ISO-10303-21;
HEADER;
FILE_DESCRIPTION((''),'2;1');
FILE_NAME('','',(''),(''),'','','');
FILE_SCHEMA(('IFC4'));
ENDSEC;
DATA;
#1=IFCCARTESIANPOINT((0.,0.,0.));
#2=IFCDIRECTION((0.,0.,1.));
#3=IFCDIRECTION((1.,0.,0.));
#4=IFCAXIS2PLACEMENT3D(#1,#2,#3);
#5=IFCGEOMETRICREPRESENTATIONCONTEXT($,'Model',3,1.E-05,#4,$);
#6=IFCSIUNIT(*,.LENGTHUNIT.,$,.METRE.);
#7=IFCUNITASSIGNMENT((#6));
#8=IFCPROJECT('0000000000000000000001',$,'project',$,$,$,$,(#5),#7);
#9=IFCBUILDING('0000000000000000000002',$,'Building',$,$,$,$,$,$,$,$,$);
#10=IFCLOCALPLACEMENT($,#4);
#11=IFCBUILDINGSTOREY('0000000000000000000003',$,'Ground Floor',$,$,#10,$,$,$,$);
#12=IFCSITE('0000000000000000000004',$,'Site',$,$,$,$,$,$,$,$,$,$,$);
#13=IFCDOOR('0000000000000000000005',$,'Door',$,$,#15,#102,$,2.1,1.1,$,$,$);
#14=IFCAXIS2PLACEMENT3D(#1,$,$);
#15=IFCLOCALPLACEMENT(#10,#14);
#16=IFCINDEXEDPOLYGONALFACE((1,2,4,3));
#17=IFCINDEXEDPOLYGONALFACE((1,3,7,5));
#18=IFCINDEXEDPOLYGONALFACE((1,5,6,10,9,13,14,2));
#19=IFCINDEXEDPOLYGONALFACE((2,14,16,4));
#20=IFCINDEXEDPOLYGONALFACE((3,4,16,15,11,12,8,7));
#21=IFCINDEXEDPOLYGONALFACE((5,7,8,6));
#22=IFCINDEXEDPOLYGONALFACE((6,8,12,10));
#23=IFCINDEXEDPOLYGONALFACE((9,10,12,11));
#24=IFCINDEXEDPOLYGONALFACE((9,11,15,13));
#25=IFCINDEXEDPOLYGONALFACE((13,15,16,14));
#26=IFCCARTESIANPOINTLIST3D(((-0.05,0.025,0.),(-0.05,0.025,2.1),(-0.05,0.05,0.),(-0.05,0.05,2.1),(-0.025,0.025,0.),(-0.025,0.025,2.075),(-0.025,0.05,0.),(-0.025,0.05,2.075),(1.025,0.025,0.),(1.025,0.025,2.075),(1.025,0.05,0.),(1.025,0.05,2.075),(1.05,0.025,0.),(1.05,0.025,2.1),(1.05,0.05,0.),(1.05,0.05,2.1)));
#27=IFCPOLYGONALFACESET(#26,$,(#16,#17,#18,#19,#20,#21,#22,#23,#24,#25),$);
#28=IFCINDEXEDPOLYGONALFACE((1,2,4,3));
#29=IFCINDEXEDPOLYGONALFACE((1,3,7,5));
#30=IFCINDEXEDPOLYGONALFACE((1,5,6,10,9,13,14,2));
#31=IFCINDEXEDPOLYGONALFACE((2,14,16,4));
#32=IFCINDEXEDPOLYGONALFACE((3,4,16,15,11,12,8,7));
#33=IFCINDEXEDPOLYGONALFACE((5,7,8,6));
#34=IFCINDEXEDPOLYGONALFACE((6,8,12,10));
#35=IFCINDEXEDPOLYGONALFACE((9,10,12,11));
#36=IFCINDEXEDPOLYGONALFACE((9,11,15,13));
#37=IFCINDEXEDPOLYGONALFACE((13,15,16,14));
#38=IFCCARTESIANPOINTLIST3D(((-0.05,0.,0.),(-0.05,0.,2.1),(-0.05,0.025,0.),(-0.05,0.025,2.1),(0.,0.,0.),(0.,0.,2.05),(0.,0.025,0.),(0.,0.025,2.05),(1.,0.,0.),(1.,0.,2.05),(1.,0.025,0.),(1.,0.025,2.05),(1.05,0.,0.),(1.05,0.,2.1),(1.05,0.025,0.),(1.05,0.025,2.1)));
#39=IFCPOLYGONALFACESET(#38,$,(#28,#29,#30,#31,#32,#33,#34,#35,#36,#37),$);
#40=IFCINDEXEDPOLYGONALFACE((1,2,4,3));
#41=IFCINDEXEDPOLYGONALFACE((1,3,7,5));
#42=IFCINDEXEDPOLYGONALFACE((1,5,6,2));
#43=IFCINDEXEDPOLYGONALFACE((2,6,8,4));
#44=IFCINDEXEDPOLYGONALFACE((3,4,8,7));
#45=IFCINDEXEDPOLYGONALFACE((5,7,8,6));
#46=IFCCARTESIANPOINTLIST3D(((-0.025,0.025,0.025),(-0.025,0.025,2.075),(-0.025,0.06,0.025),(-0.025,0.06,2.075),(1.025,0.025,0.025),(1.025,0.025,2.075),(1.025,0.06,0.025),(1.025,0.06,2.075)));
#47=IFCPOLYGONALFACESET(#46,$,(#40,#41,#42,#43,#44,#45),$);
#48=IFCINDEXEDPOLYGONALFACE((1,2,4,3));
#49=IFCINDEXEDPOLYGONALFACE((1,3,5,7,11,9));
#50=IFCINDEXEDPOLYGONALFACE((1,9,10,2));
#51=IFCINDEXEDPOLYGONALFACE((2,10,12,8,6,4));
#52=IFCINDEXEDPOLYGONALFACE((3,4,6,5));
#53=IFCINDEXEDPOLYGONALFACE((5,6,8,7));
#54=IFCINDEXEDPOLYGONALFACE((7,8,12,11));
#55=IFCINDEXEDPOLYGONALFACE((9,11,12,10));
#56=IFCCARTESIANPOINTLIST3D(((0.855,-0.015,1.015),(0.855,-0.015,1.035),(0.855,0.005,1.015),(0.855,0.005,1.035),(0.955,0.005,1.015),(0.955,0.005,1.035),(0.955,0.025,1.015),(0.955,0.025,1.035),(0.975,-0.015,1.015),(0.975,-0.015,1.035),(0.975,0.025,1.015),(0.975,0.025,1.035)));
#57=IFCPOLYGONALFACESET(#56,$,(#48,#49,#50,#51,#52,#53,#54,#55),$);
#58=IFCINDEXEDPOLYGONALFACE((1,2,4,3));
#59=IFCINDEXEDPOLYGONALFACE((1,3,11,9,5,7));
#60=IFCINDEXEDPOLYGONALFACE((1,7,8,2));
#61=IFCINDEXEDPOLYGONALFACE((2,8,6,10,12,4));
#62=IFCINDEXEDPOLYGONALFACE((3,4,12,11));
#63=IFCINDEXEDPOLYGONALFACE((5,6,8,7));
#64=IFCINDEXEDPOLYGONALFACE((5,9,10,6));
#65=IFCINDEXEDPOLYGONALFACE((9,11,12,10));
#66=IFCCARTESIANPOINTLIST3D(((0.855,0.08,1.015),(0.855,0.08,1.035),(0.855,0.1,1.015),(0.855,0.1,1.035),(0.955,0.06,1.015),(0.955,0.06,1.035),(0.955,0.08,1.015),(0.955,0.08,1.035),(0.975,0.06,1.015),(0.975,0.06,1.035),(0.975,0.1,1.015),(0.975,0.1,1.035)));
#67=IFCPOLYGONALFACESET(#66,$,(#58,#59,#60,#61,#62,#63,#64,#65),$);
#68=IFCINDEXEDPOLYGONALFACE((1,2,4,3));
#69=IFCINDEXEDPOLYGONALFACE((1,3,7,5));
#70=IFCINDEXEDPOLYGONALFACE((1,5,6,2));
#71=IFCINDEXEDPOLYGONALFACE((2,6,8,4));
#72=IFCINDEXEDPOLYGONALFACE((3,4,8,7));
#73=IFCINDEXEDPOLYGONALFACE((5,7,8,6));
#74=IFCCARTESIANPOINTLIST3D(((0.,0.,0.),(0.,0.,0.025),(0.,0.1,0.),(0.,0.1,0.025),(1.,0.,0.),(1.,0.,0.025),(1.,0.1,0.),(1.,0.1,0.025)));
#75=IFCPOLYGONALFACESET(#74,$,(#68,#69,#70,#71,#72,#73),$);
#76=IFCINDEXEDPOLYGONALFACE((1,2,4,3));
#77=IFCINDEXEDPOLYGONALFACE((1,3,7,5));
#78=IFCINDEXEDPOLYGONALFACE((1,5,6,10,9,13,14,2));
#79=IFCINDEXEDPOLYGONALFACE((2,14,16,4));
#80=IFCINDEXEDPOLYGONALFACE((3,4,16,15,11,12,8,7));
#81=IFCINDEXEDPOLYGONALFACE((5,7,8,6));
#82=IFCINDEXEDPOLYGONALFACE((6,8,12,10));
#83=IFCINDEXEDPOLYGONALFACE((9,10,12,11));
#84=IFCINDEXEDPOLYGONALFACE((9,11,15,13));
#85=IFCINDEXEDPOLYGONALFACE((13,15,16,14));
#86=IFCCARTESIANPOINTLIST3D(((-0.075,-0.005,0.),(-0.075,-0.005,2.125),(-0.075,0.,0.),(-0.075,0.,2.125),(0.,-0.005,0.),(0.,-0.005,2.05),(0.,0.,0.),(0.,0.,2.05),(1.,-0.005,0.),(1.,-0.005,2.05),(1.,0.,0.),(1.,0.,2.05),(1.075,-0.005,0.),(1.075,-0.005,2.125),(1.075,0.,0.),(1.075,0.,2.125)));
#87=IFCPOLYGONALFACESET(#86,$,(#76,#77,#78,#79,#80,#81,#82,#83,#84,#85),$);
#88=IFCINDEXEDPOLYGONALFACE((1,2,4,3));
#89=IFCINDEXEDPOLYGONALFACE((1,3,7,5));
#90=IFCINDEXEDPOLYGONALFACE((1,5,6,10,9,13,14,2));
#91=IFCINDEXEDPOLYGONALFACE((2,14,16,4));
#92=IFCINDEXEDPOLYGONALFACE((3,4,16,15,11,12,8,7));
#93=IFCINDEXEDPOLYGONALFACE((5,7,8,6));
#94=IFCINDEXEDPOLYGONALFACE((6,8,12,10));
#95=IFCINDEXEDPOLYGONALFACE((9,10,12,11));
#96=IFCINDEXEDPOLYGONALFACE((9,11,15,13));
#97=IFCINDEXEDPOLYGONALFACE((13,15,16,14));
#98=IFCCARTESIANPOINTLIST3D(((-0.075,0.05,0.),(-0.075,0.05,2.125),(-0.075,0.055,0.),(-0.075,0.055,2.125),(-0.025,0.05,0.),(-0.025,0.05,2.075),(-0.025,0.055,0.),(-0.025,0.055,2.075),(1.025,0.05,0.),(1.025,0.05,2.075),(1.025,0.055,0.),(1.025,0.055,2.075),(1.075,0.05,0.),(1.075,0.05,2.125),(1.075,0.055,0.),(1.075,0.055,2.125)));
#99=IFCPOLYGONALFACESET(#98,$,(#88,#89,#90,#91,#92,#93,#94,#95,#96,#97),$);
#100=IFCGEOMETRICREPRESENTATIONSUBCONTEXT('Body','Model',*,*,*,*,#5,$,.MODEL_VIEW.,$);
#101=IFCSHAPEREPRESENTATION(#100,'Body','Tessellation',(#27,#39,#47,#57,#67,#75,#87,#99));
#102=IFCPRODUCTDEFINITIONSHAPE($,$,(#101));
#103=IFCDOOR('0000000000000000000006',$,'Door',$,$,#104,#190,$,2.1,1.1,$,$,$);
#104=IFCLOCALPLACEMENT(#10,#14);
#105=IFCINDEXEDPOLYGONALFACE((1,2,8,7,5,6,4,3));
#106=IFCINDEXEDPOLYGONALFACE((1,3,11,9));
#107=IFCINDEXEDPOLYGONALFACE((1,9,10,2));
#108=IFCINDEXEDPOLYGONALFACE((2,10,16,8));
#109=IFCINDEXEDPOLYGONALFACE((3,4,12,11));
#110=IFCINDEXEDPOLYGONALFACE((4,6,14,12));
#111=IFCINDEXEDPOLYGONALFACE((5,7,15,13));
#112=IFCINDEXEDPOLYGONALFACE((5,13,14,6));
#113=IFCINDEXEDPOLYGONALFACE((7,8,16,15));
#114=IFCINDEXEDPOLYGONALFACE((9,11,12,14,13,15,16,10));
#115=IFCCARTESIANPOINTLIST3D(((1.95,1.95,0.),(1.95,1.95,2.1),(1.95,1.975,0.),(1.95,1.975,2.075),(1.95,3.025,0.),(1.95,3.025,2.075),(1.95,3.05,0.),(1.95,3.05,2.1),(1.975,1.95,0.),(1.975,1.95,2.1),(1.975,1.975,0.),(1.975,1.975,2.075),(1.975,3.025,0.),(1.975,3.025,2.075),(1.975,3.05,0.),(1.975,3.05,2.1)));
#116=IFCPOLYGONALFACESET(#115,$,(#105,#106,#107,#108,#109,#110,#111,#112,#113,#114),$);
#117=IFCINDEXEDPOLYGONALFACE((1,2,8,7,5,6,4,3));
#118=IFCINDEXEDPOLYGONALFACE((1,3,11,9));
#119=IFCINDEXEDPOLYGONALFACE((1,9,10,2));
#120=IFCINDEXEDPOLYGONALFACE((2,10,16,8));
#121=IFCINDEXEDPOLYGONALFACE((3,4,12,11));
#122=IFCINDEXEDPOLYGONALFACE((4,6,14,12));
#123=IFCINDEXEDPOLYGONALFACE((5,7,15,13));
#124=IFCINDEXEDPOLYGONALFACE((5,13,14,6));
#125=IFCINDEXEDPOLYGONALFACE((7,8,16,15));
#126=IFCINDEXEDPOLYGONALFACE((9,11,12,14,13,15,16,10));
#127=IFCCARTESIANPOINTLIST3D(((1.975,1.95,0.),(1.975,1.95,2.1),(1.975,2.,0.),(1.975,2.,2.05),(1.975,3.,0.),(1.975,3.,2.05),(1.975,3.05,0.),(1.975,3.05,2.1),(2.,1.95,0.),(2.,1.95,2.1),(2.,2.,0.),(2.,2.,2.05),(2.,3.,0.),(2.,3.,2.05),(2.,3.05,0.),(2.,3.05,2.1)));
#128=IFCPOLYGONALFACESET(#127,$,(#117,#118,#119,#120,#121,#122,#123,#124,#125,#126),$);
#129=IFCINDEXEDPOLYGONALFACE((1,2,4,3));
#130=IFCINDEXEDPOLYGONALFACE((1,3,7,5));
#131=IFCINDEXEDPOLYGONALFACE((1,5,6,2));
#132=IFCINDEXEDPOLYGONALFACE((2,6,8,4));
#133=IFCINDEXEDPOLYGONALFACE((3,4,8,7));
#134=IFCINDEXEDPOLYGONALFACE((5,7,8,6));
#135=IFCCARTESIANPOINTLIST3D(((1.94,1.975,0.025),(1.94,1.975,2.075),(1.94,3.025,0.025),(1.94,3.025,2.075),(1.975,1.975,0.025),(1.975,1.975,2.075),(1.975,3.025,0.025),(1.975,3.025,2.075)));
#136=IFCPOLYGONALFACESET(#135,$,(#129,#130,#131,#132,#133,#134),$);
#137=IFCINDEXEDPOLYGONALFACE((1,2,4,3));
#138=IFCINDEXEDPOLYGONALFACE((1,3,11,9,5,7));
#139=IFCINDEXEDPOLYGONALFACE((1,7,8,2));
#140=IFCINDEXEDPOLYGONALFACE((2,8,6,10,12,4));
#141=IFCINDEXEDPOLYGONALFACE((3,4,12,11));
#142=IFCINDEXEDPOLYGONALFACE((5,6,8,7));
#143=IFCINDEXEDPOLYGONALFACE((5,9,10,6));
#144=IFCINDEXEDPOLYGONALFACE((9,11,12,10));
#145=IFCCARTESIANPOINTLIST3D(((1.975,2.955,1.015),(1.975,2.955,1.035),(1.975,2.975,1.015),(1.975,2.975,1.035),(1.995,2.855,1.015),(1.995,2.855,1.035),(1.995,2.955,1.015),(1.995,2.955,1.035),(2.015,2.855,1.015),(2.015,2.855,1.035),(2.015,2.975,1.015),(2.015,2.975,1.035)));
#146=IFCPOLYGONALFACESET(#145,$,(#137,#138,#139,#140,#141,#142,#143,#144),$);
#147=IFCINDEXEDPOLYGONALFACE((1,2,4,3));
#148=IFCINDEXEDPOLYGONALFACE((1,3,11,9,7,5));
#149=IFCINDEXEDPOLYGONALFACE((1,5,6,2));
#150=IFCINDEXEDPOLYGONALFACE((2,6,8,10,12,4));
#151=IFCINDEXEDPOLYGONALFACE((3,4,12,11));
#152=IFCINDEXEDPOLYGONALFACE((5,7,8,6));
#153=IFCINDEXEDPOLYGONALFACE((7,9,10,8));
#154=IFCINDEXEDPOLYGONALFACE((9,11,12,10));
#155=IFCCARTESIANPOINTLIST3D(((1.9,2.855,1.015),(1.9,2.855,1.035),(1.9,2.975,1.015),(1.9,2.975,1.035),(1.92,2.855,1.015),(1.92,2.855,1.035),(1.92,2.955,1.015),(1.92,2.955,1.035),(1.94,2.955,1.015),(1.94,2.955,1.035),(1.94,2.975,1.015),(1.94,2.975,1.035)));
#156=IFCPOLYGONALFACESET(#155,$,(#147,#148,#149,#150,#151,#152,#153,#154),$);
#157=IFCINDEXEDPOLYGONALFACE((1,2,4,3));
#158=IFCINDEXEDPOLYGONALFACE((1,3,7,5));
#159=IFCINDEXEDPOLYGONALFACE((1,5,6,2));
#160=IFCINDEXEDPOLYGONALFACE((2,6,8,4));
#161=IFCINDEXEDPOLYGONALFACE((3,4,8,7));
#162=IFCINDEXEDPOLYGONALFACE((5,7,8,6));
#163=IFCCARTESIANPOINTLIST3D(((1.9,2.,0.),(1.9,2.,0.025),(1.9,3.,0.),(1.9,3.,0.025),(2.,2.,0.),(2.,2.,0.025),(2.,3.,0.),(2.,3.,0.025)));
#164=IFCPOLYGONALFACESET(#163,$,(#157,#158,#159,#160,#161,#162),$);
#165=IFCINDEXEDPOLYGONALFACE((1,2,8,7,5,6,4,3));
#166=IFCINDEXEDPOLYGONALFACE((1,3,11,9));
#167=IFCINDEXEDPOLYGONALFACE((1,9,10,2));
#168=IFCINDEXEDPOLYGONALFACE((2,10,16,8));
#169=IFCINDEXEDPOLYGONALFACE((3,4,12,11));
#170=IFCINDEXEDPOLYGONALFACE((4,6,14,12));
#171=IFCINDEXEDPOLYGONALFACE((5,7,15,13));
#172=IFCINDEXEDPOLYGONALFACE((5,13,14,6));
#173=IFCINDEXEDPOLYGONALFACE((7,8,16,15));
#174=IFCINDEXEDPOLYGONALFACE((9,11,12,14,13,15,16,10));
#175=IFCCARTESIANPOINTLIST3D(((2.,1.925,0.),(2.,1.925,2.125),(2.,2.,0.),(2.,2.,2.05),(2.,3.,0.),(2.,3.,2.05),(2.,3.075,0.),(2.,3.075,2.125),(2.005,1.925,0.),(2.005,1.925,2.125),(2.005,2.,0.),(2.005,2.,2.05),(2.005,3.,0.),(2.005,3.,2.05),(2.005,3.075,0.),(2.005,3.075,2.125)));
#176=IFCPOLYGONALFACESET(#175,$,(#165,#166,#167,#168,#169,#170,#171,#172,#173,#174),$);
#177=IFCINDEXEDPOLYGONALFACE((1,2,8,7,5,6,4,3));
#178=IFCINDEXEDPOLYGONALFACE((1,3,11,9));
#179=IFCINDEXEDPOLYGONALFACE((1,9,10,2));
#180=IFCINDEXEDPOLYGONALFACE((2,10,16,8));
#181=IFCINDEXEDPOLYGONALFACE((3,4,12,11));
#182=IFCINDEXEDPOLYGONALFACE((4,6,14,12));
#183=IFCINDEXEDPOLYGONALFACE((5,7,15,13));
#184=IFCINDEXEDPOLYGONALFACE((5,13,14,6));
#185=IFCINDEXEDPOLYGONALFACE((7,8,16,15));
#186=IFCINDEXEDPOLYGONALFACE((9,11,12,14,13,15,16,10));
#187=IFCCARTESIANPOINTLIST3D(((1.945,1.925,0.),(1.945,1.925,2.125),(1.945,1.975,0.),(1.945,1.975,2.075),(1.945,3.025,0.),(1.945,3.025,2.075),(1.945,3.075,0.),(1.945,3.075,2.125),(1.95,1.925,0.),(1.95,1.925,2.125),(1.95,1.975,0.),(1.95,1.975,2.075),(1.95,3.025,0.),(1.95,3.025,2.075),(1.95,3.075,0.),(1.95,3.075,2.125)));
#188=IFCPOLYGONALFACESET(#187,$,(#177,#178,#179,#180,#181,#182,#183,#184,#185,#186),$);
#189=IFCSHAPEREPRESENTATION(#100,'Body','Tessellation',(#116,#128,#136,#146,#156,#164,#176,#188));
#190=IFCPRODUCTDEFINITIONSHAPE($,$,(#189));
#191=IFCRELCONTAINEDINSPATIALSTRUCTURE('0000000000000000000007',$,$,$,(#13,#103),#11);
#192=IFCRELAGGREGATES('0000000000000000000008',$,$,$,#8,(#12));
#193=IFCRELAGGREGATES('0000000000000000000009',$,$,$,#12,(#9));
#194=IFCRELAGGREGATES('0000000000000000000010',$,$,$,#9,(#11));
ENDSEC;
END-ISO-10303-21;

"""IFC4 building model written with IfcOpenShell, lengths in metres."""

from ifc_helpers import new_model, si_unit, frame, origin_with_axes, place, context, subcontext, project, spatial, line, indexed_curve, outline, extrude, element, save


model = new_model("IFC4")

# Units and contexts
model_context = context("Model", 3, precision=1e-05, world=origin_with_axes())
body_context = subcontext(model_context, "Body", "Model", "MODEL_VIEW")
ifc_project = project(units=[si_unit("LENGTHUNIT", "METRE")], contexts=[model_context])

# Site, building, storey
site = spatial("IfcSite", under=ifc_project, Name="Site")
building = spatial("IfcBuilding", under=site, Name="Building")
storey_placement = place(None, origin_with_axes())
storey = spatial("IfcBuildingStorey", under=building, at=storey_placement, Name="Ground Floor")

# Doors
door_1_placement = place(storey_placement, frame((-0.05, 0.0, 0.0), z_axis=(0.0, 0.0, 1.0), x_axis=(1.0, 0.0, 0.0)))
element("IfcDoor", 1, at=door_1_placement, inside=storey, Name="Door", OverallHeight=2.1, OverallWidth=1.1, context=body_context, shape_type="SweptSolid", body=[
    extrude(outline(indexed_curve([(0.0, 0.0), (0.0, 2.1), (1.1, 2.1), (1.1, 0.0), (1.075, 0.0), (1.075, 2.075), (0.025, 2.075), (0.025, 0.0)], segments=[line(1, 2, 3, 4, 5, 6, 7, 8, 1)])), frame((0.0, 0.025, 0.0), z_axis=(0.0, -1.0, 0.0), x_axis=(1.0, 0.0, 0.0)), (0.0, 0.0, -1.0), 0.025),
    extrude(outline(indexed_curve([(0.0, 0.0), (0.0, 2.1), (1.1, 2.1), (1.1, 0.0), (1.05, 0.0), (1.05, 2.05), (0.05, 2.05), (0.05, 0.0)], segments=[line(1, 2, 3, 4, 5, 6, 7, 8, 1)])), frame((0.0, 0.0, 0.0), z_axis=(0.0, -1.0, 0.0), x_axis=(1.0, 0.0, 0.0)), (0.0, 0.0, -1.0), 0.025),
    extrude(outline(indexed_curve([(0.0, 0.0), (1.05, 0.0), (1.05, 0.035), (0.0, 0.035)], segments=[line(1, 2, 3, 4, 1)])), frame((0.025, 0.025, 0.025), z_axis=(0.0, 0.0, 1.0), x_axis=(1.0, 0.0, 0.0)), (0.0, 0.0, 1.0), 2.05),
    extrude(outline(indexed_curve([(0.0, 0.0), (0.0, -0.04), (-0.12, -0.04), (-0.12, -0.02), (-0.02, -0.02), (-0.02, 0.0)], segments=[line(1, 2, 3, 4, 5, 6, 1)])), frame((1.025, 0.025, 1.015), z_axis=(0.0, 0.0, 1.0), x_axis=(1.0, 0.0, 0.0)), (0.0, 0.0, 1.0), 0.02),
    extrude(outline(indexed_curve([(0.0, 0.0), (0.0, 0.04), (-0.12, 0.04), (-0.12, 0.02), (-0.02, 0.02), (-0.02, 0.0)], segments=[line(1, 2, 3, 4, 5, 6, 1)])), frame((1.025, 0.06, 1.015), z_axis=(0.0, 0.0, 1.0), x_axis=(1.0, 0.0, 0.0)), (0.0, 0.0, 1.0), 0.02),
    extrude(outline(indexed_curve([(0.0, 0.0), (1.0, 0.0), (1.0, 0.1), (0.0, 0.1)], segments=[line(1, 2, 3, 4, 1)])), frame((0.05, 0.0, 0.0), z_axis=(0.0, 0.0, 1.0), x_axis=(1.0, 0.0, 0.0)), (0.0, 0.0, 1.0), 0.025),
    extrude(outline(indexed_curve([(0.0, 0.0), (0.0, 2.125), (1.15, 2.125), (1.15, 0.0), (1.075, 0.0), (1.075, 2.05), (0.075, 2.05), (0.075, 0.0)], segments=[line(1, 2, 3, 4, 5, 6, 7, 8, 1)])), frame((-0.025, -0.005, 0.0), z_axis=(0.0, -1.0, 0.0), x_axis=(1.0, 0.0, 0.0)), (0.0, 0.0, -1.0), 0.005),
    extrude(outline(indexed_curve([(0.0, 0.0), (0.0, 2.125), (1.15, 2.125), (1.15, 0.0), (1.1, 0.0), (1.1, 2.075), (0.05, 2.075), (0.05, 0.0)], segments=[line(1, 2, 3, 4, 5, 6, 7, 8, 1)])), frame((-0.025, 0.05, 0.0), z_axis=(0.0, -1.0, 0.0), x_axis=(1.0, 0.0, 0.0)), (0.0, 0.0, -1.0), 0.005),
])
door_2_placement = place(storey_placement, frame((2.0, 1.95, 0.0), z_axis=(0.0, 0.0, 1.0), x_axis=(0.0, 1.0, 0.0)))
element("IfcDoor", 2, at=door_2_placement, inside=storey, Name="Door", OverallHeight=2.1, OverallWidth=1.1, context=body_context, shape_type="SweptSolid", body=[
    extrude(outline(indexed_curve([(0.0, 0.0), (0.0, 2.1), (1.1, 2.1), (1.1, 0.0), (1.075, 0.0), (1.075, 2.075), (0.025, 2.075), (0.025, 0.0)], segments=[line(1, 2, 3, 4, 5, 6, 7, 8, 1)])), frame((0.0, 0.025, 0.0), z_axis=(0.0, -1.0, 0.0), x_axis=(1.0, 0.0, 0.0)), (0.0, 0.0, -1.0), 0.025),
    extrude(outline(indexed_curve([(0.0, 0.0), (0.0, 2.1), (1.1, 2.1), (1.1, 0.0), (1.05, 0.0), (1.05, 2.05), (0.05, 2.05), (0.05, 0.0)], segments=[line(1, 2, 3, 4, 5, 6, 7, 8, 1)])), frame((0.0, 0.0, 0.0), z_axis=(0.0, -1.0, 0.0), x_axis=(1.0, 0.0, 0.0)), (0.0, 0.0, -1.0), 0.025),
    extrude(outline(indexed_curve([(0.0, 0.0), (1.05, 0.0), (1.05, 0.035), (0.0, 0.035)], segments=[line(1, 2, 3, 4, 1)])), frame((0.025, 0.025, 0.025), z_axis=(0.0, 0.0, 1.0), x_axis=(1.0, 0.0, 0.0)), (0.0, 0.0, 1.0), 2.05),
    extrude(outline(indexed_curve([(0.0, 0.0), (0.0, -0.04), (-0.12, -0.04), (-0.12, -0.02), (-0.02, -0.02), (-0.02, 0.0)], segments=[line(1, 2, 3, 4, 5, 6, 1)])), frame((1.025, 0.025, 1.015), z_axis=(0.0, 0.0, 1.0), x_axis=(1.0, 0.0, 0.0)), (0.0, 0.0, 1.0), 0.02),
    extrude(outline(indexed_curve([(0.0, 0.0), (0.0, 0.04), (-0.12, 0.04), (-0.12, 0.02), (-0.02, 0.02), (-0.02, 0.0)], segments=[line(1, 2, 3, 4, 5, 6, 1)])), frame((1.025, 0.06, 1.015), z_axis=(0.0, 0.0, 1.0), x_axis=(1.0, 0.0, 0.0)), (0.0, 0.0, 1.0), 0.02),
    extrude(outline(indexed_curve([(0.0, 0.0), (1.0, 0.0), (1.0, 0.1), (0.0, 0.1)], segments=[line(1, 2, 3, 4, 1)])), frame((0.05, 0.0, 0.0), z_axis=(0.0, 0.0, 1.0), x_axis=(1.0, 0.0, 0.0)), (0.0, 0.0, 1.0), 0.025),
    extrude(outline(indexed_curve([(0.0, 0.0), (0.0, 2.125), (1.15, 2.125), (1.15, 0.0), (1.075, 0.0), (1.075, 2.05), (0.075, 2.05), (0.075, 0.0)], segments=[line(1, 2, 3, 4, 5, 6, 7, 8, 1)])), frame((-0.025, -0.005, 0.0), z_axis=(0.0, -1.0, 0.0), x_axis=(1.0, 0.0, 0.0)), (0.0, 0.0, -1.0), 0.005),
    extrude(outline(indexed_curve([(0.0, 0.0), (0.0, 2.125), (1.15, 2.125), (1.15, 0.0), (1.1, 0.0), (1.1, 2.075), (0.05, 2.075), (0.05, 0.0)], segments=[line(1, 2, 3, 4, 5, 6, 7, 8, 1)])), frame((-0.025, 0.05, 0.0), z_axis=(0.0, -1.0, 0.0), x_axis=(1.0, 0.0, 0.0)), (0.0, 0.0, -1.0), 0.005),
])

save(model, "model.ifc")
